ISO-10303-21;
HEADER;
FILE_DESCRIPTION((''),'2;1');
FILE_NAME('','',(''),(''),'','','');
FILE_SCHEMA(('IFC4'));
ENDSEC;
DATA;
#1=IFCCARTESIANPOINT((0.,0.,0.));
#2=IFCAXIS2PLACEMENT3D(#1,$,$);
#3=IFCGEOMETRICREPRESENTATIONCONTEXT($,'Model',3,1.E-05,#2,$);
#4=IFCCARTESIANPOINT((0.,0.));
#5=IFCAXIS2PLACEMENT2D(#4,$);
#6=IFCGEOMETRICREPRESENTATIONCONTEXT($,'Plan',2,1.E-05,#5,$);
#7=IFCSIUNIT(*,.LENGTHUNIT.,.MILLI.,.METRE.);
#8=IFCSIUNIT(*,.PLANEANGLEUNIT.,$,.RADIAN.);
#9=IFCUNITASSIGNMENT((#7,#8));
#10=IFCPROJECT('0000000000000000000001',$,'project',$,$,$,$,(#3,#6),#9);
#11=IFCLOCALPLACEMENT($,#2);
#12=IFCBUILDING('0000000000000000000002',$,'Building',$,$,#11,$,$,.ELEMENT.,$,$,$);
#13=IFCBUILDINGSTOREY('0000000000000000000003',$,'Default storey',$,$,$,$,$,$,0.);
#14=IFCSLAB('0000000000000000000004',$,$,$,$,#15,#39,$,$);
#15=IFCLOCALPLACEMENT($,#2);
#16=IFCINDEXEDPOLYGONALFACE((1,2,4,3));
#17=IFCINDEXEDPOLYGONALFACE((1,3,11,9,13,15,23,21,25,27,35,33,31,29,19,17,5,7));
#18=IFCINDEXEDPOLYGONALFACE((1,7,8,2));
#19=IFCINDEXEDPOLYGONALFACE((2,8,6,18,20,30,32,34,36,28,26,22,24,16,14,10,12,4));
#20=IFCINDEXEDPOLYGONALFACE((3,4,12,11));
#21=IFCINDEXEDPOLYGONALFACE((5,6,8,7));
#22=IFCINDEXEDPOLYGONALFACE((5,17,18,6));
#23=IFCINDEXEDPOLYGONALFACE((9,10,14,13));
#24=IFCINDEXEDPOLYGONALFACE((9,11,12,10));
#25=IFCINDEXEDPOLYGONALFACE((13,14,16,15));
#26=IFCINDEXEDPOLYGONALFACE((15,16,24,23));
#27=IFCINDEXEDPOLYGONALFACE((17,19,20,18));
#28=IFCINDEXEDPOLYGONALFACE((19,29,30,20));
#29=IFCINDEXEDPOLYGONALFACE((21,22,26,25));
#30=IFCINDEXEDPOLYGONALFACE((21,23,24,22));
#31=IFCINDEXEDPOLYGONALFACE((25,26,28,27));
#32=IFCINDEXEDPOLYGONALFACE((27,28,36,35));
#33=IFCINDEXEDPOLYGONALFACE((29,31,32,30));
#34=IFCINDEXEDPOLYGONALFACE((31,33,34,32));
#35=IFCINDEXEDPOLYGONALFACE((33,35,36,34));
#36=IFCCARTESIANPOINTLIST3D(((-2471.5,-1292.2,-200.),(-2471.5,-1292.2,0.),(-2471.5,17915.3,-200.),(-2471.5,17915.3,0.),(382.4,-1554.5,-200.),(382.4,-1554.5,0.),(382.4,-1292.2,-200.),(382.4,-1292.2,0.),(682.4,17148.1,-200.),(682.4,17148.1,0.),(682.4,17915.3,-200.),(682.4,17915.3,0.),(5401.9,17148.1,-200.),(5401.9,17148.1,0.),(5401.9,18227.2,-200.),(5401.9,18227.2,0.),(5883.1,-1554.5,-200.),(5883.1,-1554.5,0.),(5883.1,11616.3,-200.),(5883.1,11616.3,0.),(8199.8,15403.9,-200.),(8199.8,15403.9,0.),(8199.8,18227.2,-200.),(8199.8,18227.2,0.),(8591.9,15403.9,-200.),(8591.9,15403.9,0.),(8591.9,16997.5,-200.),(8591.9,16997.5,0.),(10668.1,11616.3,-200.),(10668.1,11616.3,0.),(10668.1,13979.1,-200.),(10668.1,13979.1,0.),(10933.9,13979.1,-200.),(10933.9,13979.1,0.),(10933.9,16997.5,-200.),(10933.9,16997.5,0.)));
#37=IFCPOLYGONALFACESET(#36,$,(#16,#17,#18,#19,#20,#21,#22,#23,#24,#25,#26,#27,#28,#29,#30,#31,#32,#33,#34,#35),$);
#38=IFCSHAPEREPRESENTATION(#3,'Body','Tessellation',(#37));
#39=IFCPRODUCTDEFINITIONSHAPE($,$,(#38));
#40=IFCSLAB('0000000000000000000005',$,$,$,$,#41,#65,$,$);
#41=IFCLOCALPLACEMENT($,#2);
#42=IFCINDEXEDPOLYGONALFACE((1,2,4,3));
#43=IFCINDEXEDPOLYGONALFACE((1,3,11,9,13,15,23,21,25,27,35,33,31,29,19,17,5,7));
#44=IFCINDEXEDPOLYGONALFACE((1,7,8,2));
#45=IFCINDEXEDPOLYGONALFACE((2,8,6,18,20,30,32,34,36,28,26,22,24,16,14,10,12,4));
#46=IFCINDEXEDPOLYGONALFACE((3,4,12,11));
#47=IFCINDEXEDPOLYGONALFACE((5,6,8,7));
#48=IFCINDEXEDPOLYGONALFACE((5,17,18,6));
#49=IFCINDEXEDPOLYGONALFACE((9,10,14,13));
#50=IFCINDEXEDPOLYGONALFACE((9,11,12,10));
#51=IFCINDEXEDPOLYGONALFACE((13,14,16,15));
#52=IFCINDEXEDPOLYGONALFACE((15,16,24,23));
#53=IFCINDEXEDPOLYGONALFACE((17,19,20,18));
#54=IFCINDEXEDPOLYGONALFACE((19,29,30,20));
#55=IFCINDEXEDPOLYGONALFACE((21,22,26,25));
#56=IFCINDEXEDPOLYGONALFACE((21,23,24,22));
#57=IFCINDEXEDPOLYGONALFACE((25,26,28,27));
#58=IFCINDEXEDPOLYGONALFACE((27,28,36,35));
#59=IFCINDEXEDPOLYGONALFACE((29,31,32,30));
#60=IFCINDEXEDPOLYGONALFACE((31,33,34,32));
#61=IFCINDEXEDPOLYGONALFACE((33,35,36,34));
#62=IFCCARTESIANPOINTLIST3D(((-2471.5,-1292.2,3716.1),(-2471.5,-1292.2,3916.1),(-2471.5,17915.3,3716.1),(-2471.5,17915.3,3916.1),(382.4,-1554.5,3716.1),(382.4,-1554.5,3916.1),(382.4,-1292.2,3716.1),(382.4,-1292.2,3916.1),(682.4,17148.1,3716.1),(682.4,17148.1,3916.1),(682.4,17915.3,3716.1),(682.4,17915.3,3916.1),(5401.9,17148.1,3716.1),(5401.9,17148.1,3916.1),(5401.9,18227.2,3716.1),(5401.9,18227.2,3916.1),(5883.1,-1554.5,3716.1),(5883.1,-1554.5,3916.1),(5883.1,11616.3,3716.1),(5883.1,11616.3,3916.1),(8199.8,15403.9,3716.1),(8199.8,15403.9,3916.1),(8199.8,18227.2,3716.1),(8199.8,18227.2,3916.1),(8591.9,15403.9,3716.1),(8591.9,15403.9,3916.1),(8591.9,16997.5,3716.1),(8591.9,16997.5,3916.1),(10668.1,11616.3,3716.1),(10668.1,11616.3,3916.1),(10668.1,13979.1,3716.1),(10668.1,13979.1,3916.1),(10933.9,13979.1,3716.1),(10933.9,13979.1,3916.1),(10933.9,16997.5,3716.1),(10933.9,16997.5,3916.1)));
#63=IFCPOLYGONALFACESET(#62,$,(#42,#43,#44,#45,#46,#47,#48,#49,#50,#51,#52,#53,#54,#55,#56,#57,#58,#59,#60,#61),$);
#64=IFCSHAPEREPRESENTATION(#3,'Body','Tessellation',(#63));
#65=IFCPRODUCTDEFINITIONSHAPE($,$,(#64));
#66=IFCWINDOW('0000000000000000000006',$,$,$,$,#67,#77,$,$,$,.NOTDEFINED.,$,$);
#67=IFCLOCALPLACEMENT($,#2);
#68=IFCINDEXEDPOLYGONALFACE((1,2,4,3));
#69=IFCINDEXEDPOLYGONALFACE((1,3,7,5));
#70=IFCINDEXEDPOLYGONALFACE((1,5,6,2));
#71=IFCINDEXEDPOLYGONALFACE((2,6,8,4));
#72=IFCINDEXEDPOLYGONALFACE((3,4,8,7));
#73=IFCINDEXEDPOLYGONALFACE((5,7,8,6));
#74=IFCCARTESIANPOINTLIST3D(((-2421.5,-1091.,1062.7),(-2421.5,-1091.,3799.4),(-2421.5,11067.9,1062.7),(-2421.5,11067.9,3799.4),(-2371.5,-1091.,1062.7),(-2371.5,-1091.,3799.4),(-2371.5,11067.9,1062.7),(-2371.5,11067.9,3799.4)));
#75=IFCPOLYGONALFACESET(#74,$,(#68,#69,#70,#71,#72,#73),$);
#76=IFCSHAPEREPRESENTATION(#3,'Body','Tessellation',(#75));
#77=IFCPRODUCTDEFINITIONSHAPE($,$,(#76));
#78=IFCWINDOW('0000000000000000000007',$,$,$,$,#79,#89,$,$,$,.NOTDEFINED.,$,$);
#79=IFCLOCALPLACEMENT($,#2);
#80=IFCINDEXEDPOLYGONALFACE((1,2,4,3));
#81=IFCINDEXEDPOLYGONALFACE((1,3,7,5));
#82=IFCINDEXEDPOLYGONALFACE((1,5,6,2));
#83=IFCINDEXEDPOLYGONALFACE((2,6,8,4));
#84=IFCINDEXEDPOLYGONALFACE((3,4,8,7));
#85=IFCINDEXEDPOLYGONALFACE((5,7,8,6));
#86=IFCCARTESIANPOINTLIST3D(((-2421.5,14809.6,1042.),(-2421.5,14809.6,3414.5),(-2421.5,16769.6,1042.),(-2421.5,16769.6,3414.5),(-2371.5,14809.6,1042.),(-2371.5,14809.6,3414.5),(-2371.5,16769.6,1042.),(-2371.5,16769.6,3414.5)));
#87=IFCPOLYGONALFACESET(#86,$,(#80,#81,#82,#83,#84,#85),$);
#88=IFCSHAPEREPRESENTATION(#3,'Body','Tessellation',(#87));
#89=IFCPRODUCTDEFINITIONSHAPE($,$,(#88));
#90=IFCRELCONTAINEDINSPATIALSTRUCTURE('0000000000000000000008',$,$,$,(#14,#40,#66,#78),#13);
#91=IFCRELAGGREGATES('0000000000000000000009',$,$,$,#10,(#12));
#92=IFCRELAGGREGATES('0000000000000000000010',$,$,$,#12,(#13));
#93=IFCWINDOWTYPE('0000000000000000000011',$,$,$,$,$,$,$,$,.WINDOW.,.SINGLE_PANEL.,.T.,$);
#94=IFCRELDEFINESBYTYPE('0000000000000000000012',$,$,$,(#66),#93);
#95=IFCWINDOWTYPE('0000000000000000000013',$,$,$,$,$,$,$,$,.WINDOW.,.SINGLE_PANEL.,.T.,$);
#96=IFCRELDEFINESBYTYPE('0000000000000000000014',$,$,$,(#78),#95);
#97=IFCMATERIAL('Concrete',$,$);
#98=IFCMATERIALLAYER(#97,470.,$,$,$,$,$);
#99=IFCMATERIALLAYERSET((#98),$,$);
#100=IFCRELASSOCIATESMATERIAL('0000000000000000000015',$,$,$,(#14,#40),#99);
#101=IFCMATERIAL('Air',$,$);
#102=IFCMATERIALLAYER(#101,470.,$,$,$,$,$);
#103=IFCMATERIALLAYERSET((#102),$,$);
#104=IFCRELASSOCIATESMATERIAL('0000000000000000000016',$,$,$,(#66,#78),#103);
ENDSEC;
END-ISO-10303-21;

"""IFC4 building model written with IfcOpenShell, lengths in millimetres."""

from ifc_helpers import new_model, si_unit, frame, origin, origin_2d, place, context, project, spatial, polyline, rectangle, outline, extrude, boolean, material, layer, layer_set, layer_usage, type_object, element, save


model = new_model("IFC4")

# Units and contexts
model_context = context("Model", 3, precision=1e-05, world=origin())
plan_context = context("Plan", 2, precision=1e-05, world=origin_2d())
ifc_project = project(units=[si_unit("LENGTHUNIT", "METRE", prefix="MILLI"), si_unit("PLANEANGLEUNIT", "RADIAN")], contexts=[model_context, plan_context])

# Building, storey
placement = place(None, origin())
building = spatial("IfcBuilding", under=ifc_project, at=placement, Name="Building", CompositionType="ELEMENT")
storey = spatial("IfcBuildingStorey", under=building, Name="Default storey", Elevation=0.0)

# Slabs
ifc_material_1 = material(Name="Concrete")
ifc_layer_1 = layer(ifc_material_1, 470.0)
ifc_layer_set_1 = layer_set([ifc_layer_1])
ifc_layer_usage_1 = layer_usage(ifc_layer_set_1, "AXIS3", "POSITIVE", 0.0)
element("IfcSlab", 1, at=placement, inside=storey, material=ifc_layer_usage_1, context=model_context, shape_type="SweptSolid", body=[
    extrude(outline(polyline([(8591.9, 16997.5), (8591.9, 15403.9), (8199.8, 15403.9), (8199.8, 18227.2), (5401.9, 18227.2), (5401.9, 17148.1), (682.4, 17148.1), (682.4, 17915.3), (-2471.5, 17915.3), (-2471.5, -1292.2), (382.4, -1292.2), (382.4, -1554.5), (5883.1, -1554.5), (5883.1, 11616.3), (10668.1, 11616.3), (10668.1, 13979.1), (10933.9, 13979.1), (10933.9, 16997.5), (8591.9, 16997.5)])), frame((0.0, 0.0, -200.0), z_axis=(0.0, 0.0, 1000.0), x_axis=(1000.0, 0.0, 0.0)), (0.0, 0.0, 1.0), 200.0),
])
element("IfcSlab", 2, at=placement, inside=storey, material=ifc_layer_usage_1, context=model_context, shape_type="SweptSolid", body=[
    extrude(outline(polyline([(8591.9, 16997.5), (8591.9, 15403.9), (8199.8, 15403.9), (8199.8, 18227.2), (5401.9, 18227.2), (5401.9, 17148.1), (682.4, 17148.1), (682.4, 17915.3), (-2471.5, 17915.3), (-2471.5, -1292.2), (382.4, -1292.2), (382.4, -1554.5), (5883.1, -1554.5), (5883.1, 11616.3), (10668.1, 11616.3), (10668.1, 13979.1), (10933.9, 13979.1), (10933.9, 16997.5), (8591.9, 16997.5)])), frame((0.0, 0.0, 3916.1), z_axis=(0.0, 0.0, 1000.0), x_axis=(1000.0, 0.0, 0.0)), (0.0, 0.0, -1.0), 200.0),
])

# Windows
ifc_material_2 = material(Name="Air")
ifc_layer_2 = layer(ifc_material_2, 470.0)
ifc_layer_set_2 = layer_set([ifc_layer_2])
ifc_layer_usage_2 = layer_usage(ifc_layer_set_2, "AXIS3", "POSITIVE", 0.0)
window_type_1 = type_object("IfcWindowType", ParameterTakesPrecedence=True, PartitioningType="SINGLE_PANEL", PredefinedType="WINDOW")
element("IfcWindow", 3, at=placement, inside=storey, type_object=window_type_1, material=ifc_layer_usage_2, PredefinedType="NOTDEFINED", context=model_context, shape_type="CSG", body=[
    boolean("INTERSECTION", extrude(rectangle(XDim=12158.9, YDim=50.0, at=origin_2d()), frame((-2396.5, 4988.4, 1062.7), z_axis=(0.0, 0.0, 1000.0), x_axis=(0.0, 12158.909678, 0.0)), (0.0, 0.0, 1.0), 2736.7), extrude(rectangle(XDim=12158.9, YDim=50.0, at=origin_2d()), frame((-2396.5, 4988.4, 1062.7), z_axis=(0.0, 0.0, 1000.0), x_axis=(0.0, 12158.909678, 0.0)), (0.0, 0.0, 1.0), 2736.7)),
])
window_type_2 = type_object("IfcWindowType", ParameterTakesPrecedence=True, PartitioningType="SINGLE_PANEL", PredefinedType="WINDOW")
element("IfcWindow", 4, at=placement, inside=storey, type_object=window_type_2, material=ifc_layer_usage_2, PredefinedType="NOTDEFINED", context=model_context, shape_type="CSG", body=[
    boolean("INTERSECTION", extrude(rectangle(XDim=1960.0, YDim=50.0, at=origin_2d()), frame((-2396.5, 15789.6, 1042.0), z_axis=(0.0, 0.0, 1000.0), x_axis=(0.0, 1960.000038, 0.0)), (0.0, 0.0, 1.0), 2372.5), extrude(rectangle(XDim=1960.0, YDim=50.0, at=origin_2d()), frame((-2396.5, 15789.6, 1042.0), z_axis=(0.0, 0.0, 1000.0), x_axis=(0.0, 1960.000038, 0.0)), (0.0, 0.0, 1.0), 2372.5)),
])

save(model, "model.ifc")
